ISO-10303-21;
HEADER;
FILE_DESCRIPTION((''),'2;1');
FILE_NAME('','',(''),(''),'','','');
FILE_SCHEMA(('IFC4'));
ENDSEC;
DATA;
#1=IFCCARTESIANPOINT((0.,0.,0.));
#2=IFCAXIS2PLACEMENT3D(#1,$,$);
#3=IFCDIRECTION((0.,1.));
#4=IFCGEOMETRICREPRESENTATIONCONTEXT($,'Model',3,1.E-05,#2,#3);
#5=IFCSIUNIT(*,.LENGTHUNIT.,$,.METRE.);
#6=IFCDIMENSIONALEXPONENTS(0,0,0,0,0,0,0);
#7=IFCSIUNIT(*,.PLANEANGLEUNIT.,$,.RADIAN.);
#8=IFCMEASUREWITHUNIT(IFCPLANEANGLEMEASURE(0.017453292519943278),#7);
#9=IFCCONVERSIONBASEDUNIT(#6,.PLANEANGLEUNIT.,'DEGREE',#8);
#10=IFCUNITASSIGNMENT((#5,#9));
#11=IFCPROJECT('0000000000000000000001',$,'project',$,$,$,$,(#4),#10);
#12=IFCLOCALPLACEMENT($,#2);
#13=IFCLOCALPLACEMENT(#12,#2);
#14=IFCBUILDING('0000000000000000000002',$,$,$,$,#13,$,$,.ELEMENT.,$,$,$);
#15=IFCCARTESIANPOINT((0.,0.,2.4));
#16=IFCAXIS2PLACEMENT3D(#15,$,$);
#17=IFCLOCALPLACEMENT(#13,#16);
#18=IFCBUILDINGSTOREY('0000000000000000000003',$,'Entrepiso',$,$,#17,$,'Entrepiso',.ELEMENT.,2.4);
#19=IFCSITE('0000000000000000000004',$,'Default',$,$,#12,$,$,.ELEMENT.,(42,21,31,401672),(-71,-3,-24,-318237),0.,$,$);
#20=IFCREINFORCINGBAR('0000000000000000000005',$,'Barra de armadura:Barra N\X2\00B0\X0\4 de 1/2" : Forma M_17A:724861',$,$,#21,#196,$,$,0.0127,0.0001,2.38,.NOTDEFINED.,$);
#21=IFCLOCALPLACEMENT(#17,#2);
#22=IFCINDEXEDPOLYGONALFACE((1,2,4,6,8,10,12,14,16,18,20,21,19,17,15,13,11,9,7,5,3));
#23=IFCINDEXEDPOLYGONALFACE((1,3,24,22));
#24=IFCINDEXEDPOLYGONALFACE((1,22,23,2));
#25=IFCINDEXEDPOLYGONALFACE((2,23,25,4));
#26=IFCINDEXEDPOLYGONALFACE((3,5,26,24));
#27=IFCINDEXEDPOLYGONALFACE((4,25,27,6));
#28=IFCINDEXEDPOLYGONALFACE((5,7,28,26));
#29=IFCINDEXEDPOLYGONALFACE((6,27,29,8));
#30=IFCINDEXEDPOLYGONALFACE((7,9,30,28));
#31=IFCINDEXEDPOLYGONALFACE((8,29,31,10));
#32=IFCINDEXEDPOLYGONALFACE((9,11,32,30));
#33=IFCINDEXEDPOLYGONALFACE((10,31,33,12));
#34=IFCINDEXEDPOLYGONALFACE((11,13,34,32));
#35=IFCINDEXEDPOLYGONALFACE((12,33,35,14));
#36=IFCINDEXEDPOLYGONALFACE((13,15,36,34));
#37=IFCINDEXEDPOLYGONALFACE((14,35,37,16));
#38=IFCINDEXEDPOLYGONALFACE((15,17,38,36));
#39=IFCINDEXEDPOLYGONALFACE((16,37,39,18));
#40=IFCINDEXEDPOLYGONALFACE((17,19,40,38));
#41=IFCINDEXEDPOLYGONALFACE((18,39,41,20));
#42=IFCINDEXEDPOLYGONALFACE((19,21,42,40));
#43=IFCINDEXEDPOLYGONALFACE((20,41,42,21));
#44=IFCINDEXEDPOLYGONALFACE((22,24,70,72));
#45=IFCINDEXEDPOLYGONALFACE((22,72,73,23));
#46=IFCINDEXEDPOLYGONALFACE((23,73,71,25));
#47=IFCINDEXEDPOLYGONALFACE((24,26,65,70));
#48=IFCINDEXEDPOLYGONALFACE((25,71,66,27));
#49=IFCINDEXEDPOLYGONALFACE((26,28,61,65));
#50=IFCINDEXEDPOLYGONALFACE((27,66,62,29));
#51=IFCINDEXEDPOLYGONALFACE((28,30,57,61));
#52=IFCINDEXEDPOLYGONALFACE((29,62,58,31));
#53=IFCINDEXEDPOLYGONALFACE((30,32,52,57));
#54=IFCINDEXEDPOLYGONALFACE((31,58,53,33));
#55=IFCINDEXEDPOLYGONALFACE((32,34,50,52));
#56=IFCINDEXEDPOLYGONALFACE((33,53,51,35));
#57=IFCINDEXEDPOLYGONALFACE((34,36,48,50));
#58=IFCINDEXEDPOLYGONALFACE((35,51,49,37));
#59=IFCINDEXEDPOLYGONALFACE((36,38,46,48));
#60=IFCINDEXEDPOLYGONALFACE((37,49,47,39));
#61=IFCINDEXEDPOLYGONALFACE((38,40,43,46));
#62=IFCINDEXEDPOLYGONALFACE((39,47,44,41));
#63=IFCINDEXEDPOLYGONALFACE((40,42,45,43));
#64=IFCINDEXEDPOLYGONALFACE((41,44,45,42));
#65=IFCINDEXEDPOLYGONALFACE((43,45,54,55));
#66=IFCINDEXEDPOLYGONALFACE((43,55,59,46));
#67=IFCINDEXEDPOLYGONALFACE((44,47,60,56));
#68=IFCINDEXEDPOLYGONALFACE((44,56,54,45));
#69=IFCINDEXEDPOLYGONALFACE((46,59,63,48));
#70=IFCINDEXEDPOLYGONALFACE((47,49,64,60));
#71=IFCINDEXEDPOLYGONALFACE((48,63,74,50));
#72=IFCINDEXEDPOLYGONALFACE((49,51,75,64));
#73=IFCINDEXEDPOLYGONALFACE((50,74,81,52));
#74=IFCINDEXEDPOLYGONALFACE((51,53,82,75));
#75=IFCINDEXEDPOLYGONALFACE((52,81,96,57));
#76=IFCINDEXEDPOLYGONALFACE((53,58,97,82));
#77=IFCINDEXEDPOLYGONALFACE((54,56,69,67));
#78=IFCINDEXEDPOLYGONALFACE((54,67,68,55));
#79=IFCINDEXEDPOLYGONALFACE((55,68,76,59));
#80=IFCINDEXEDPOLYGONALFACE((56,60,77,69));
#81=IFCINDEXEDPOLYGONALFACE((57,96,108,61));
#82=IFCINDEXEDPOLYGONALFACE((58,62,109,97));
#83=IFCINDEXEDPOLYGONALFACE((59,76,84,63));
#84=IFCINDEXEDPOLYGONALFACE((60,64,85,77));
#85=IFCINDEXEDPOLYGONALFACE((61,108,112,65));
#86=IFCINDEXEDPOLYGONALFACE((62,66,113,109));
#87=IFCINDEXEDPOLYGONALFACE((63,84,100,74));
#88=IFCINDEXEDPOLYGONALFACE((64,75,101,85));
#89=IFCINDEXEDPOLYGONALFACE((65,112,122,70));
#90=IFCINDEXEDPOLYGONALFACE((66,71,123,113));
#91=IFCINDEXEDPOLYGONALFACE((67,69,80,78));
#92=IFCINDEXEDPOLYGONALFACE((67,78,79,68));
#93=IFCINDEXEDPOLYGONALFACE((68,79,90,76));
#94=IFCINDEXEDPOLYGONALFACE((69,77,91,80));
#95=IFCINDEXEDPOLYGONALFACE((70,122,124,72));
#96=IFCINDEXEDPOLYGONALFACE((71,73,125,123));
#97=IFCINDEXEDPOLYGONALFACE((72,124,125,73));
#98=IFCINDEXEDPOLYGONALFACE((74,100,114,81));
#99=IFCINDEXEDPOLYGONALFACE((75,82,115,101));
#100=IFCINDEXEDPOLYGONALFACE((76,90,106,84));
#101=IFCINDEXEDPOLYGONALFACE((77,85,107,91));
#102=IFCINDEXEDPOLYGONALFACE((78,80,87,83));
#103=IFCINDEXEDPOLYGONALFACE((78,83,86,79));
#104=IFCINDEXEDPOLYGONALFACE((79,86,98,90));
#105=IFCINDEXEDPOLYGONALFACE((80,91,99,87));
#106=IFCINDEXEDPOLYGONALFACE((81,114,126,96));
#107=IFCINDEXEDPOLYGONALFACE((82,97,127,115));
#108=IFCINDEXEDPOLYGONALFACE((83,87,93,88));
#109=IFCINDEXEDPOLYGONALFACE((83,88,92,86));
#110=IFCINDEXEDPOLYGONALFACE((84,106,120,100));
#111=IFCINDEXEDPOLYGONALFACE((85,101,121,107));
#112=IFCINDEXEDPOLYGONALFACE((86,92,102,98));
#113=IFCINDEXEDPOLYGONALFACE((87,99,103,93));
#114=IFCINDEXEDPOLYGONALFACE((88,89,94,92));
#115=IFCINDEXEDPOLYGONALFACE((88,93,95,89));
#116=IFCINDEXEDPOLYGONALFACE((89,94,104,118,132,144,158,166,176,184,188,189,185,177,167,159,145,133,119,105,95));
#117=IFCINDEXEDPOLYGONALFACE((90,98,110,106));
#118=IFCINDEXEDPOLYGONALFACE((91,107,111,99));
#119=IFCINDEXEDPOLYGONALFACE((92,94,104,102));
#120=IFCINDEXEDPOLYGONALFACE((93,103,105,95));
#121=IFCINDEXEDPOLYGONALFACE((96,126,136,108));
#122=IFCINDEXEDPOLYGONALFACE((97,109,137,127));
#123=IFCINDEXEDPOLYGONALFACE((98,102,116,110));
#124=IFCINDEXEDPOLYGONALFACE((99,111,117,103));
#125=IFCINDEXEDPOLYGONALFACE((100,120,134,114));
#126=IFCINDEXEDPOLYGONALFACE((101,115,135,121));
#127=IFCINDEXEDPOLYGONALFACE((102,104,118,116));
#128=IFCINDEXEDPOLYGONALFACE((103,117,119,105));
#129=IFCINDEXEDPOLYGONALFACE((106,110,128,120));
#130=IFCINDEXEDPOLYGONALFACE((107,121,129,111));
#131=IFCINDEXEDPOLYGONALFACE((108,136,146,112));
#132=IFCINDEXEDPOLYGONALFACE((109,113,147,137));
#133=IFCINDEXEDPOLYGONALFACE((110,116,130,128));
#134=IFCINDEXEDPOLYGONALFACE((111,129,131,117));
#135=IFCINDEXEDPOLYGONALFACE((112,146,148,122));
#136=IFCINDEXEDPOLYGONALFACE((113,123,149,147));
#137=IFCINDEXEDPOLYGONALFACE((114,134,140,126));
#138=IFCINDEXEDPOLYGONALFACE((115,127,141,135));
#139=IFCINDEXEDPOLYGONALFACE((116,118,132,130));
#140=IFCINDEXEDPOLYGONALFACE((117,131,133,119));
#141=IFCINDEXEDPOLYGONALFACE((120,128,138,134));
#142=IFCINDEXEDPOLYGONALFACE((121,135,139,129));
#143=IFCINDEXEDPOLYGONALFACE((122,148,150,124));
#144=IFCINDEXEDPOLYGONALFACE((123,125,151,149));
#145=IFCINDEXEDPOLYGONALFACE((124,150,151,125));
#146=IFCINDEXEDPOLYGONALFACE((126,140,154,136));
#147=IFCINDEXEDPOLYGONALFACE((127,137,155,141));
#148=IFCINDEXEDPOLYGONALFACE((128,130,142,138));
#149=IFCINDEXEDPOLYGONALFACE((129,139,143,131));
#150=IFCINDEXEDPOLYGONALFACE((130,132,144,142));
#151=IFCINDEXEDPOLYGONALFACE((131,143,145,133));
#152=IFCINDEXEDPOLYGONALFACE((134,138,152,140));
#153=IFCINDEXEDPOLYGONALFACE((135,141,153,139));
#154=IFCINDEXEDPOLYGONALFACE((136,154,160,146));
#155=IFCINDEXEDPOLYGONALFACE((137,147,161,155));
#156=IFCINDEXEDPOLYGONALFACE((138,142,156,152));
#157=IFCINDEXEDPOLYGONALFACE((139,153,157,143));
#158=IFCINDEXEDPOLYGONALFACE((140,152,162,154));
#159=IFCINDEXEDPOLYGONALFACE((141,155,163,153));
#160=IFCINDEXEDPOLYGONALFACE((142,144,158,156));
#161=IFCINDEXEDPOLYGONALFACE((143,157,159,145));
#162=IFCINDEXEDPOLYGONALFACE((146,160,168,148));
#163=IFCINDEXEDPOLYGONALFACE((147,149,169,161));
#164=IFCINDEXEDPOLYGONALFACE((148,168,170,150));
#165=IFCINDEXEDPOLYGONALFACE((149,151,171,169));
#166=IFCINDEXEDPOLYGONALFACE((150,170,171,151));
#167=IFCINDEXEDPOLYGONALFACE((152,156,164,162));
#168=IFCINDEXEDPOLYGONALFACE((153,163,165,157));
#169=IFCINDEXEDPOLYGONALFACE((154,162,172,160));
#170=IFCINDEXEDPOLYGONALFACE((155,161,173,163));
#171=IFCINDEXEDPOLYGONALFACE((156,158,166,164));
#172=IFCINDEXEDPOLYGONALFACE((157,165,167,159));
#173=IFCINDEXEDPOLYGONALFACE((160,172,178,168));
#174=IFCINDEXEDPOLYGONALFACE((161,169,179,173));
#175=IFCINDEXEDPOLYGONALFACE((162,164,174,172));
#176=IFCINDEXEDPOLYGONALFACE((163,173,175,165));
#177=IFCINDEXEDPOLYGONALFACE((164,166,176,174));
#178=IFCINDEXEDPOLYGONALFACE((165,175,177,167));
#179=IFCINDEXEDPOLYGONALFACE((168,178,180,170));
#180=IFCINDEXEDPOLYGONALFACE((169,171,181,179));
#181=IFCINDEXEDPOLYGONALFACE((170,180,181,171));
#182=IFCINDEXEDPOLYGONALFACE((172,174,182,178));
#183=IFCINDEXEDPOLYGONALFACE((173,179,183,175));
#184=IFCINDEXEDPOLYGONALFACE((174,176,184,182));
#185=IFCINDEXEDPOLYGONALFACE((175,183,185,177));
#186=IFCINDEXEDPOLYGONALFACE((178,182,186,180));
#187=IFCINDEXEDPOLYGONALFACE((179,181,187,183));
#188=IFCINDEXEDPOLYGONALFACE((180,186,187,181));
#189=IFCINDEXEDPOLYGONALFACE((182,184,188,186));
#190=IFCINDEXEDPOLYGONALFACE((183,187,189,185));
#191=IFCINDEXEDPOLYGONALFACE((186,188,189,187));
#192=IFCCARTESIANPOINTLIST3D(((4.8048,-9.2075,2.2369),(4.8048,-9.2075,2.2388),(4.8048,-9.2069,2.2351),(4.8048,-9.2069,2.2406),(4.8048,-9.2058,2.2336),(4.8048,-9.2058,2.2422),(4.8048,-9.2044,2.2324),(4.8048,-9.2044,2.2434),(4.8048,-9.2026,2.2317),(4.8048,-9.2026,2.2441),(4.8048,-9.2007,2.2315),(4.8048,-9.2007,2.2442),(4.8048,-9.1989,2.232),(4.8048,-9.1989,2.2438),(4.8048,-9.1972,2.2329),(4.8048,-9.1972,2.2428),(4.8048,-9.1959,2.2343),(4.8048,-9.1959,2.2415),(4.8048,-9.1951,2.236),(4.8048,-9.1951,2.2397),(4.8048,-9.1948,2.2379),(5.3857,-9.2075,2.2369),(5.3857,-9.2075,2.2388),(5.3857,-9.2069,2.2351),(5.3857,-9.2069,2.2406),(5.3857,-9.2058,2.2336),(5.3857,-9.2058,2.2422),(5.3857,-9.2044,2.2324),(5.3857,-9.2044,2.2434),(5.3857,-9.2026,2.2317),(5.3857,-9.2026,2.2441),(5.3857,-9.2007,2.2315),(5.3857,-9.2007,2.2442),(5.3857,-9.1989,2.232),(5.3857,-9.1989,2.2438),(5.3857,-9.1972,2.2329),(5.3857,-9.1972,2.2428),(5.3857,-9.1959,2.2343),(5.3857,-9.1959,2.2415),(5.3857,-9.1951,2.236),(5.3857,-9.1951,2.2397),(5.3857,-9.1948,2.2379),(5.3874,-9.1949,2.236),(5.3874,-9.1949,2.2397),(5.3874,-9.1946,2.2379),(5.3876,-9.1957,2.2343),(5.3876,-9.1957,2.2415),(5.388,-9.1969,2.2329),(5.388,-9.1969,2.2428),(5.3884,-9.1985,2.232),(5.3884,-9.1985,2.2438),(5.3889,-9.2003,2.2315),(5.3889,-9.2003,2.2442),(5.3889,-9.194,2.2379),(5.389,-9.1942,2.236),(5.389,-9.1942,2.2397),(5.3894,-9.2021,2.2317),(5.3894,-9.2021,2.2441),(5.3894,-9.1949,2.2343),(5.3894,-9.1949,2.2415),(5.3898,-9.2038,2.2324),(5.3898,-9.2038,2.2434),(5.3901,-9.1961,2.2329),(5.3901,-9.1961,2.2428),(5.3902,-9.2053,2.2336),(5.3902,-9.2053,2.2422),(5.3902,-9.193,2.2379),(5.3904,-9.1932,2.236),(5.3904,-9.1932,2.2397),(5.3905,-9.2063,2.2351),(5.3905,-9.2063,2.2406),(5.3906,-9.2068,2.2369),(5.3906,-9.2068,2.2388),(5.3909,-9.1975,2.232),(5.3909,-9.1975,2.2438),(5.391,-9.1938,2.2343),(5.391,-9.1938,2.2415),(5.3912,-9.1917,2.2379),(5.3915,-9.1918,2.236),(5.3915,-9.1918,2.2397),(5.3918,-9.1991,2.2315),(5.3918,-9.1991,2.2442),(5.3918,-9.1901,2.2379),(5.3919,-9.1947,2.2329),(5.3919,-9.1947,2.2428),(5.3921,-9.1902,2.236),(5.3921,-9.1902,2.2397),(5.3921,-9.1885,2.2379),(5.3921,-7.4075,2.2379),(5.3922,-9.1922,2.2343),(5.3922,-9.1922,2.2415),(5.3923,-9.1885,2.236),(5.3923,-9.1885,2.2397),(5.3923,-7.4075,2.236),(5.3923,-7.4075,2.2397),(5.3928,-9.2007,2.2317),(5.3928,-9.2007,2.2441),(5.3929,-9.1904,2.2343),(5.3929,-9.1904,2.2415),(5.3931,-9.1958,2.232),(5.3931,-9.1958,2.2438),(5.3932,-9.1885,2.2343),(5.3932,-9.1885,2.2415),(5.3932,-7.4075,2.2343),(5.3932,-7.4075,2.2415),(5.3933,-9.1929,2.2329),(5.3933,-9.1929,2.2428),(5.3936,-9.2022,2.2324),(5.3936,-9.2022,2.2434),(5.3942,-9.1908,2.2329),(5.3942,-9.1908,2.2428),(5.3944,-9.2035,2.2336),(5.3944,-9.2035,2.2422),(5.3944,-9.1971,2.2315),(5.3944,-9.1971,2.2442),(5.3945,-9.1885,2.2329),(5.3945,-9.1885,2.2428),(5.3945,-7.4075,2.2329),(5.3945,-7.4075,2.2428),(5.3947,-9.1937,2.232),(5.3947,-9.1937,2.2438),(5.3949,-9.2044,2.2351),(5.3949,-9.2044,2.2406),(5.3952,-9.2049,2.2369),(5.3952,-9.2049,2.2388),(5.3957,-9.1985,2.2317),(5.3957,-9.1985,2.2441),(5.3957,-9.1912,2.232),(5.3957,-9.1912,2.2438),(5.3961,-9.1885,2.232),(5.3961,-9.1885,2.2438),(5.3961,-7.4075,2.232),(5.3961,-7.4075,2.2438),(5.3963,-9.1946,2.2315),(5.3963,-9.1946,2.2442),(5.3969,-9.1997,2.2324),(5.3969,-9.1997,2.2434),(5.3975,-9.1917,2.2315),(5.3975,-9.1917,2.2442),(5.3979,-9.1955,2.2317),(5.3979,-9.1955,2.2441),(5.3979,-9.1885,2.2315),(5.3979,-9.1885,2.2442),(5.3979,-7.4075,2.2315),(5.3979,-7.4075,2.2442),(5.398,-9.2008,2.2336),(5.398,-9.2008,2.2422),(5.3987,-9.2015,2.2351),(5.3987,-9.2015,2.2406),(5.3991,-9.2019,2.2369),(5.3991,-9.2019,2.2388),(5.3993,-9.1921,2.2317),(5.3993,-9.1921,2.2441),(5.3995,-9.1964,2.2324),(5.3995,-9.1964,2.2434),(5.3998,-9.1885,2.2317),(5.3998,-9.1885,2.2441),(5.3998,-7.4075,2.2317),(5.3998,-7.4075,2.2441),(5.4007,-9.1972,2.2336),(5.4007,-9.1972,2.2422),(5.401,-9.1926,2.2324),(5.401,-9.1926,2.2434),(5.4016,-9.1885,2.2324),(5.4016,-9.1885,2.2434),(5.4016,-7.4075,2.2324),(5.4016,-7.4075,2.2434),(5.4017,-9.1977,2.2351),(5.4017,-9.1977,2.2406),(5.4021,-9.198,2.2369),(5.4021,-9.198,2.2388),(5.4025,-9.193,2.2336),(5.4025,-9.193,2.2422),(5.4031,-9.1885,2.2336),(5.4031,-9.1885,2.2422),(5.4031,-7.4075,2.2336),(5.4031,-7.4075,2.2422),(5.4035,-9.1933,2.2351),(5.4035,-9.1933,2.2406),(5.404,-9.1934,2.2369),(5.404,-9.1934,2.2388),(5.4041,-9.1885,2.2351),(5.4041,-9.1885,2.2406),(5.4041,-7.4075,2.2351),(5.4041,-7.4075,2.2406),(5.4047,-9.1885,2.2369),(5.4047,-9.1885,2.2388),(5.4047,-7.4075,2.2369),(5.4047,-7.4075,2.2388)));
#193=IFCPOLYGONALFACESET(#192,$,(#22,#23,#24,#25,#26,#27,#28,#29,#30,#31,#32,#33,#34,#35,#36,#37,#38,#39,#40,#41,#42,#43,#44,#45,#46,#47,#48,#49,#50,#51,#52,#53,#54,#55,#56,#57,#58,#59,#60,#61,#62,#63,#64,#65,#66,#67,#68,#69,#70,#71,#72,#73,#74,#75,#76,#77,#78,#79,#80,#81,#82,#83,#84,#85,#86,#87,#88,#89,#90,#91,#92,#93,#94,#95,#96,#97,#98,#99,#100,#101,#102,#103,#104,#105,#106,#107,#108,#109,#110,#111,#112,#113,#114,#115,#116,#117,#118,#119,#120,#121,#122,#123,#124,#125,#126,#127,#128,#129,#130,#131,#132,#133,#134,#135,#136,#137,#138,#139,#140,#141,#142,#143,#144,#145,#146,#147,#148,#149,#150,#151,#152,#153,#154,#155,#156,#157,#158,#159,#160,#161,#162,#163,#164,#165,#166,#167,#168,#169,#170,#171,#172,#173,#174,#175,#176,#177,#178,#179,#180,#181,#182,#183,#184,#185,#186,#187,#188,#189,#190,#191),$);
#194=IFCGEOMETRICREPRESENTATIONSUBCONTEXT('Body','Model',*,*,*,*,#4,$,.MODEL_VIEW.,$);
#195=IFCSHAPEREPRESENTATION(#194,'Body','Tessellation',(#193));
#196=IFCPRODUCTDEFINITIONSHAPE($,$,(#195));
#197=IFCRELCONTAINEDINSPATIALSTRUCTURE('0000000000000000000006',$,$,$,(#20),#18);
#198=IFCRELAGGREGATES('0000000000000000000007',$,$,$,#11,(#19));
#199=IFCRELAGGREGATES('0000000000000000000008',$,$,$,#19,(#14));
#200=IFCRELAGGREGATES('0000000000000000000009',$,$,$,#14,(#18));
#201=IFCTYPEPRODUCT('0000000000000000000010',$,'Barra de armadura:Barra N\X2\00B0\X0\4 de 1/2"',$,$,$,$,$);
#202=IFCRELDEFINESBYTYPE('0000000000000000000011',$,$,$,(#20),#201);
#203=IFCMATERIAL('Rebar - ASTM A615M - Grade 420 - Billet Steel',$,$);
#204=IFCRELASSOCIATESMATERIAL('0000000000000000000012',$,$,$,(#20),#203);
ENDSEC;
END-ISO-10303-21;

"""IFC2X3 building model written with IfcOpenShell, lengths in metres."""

from ifc_helpers import new_model, entity, si_unit, converted_unit, direction, frame, origin, place, context, subcontext, project, spatial, material, type_object, element, save


model = new_model("IFC2X3")

# Units and contexts
model_context = context("Model", 3, precision=1e-05, world=origin(), true_north=direction((0.0, 1.0)))
body_context = subcontext(model_context, "Body", "Model", "MODEL_VIEW")
ifc_project = project(units=[si_unit("LENGTHUNIT", "METRE"), converted_unit("PLANEANGLEUNIT", "DEGREE", entity("IfcPlaneAngleMeasure", 0.017453292519943278), si_unit("PLANEANGLEUNIT", "RADIAN"), dimensions=[0, 0, 0, 0, 0, 0, 0])], contexts=[model_context])

# Site, building, storey
site_placement = place(None, origin())
site = spatial("IfcSite", under=ifc_project, at=site_placement, Name="Default", CompositionType="ELEMENT", RefLatitude=(42, 21, 31, 401672), RefLongitude=(-71, -3, -24, -318237), RefElevation=0.0)
building_placement = place(site_placement, origin())
building = spatial("IfcBuilding", under=site, at=building_placement, CompositionType="ELEMENT")
storey_placement = place(building_placement, frame((0.0, 0.0, 2.4)))
storey = spatial("IfcBuildingStorey", under=building, at=storey_placement, Name="Entrepiso", LongName="Entrepiso", CompositionType="ELEMENT", Elevation=2.4)

# Reinforcing bar
ifc_material = material(Name="Rebar - ASTM A615M - Grade 420 - Billet Steel")
type_product_1 = type_object("IfcTypeProduct", Name="Barra de armadura:Barra N°4 de 1/2\"")
reinforcing_bar_1_placement = place(storey_placement, origin())
element("IfcReinforcingBar", 1, at=reinforcing_bar_1_placement, inside=storey, type_object=type_product_1, material=ifc_material, Name="Barra de armadura:Barra N°4 de 1/2\" : Forma M_17A:724861", BarLength=2.38, BarRole="NOTDEFINED", CrossSectionArea=0.0001, NominalDiameter=0.0127, context=body_context, shape_type="AdvancedSweptSolid", body=[
    entity("IfcSweptDiskSolid", entity("IfcCompositeCurve", [entity("IfcCompositeCurveSegment", "CONTINUOUS", True, entity("IfcPolyline", [entity("IfcCartesianPoint", [5.3984, -7.4075, 2.2379]), entity("IfcCartesianPoint", [5.3984, -9.1885, 2.2379])])), entity("IfcCompositeCurveSegment", "CONTINUOUS", True, entity("IfcTrimmedCurve", entity("IfcCircle", entity("IfcAxis2Placement3D", entity("IfcCartesianPoint", [5.3857, -9.1885, 2.2379]), entity("IfcDirection", [0.0, 0.0, -1.0]), entity("IfcDirection", [0.0, -1.0, 0.0])), 0.0127), [entity("IfcParameterValue", 270.0)], [entity("IfcParameterValue", 360.0)], True, "PARAMETER")), entity("IfcCompositeCurveSegment", "CONTINUOUS", True, entity("IfcPolyline", [entity("IfcCartesianPoint", [5.3857, -9.2012, 2.2379]), entity("IfcCartesianPoint", [4.8048, -9.2012, 2.2379])]))], False), 0.0063, None, 0.0, 92.0),
])

save(model, "model.ifc")
